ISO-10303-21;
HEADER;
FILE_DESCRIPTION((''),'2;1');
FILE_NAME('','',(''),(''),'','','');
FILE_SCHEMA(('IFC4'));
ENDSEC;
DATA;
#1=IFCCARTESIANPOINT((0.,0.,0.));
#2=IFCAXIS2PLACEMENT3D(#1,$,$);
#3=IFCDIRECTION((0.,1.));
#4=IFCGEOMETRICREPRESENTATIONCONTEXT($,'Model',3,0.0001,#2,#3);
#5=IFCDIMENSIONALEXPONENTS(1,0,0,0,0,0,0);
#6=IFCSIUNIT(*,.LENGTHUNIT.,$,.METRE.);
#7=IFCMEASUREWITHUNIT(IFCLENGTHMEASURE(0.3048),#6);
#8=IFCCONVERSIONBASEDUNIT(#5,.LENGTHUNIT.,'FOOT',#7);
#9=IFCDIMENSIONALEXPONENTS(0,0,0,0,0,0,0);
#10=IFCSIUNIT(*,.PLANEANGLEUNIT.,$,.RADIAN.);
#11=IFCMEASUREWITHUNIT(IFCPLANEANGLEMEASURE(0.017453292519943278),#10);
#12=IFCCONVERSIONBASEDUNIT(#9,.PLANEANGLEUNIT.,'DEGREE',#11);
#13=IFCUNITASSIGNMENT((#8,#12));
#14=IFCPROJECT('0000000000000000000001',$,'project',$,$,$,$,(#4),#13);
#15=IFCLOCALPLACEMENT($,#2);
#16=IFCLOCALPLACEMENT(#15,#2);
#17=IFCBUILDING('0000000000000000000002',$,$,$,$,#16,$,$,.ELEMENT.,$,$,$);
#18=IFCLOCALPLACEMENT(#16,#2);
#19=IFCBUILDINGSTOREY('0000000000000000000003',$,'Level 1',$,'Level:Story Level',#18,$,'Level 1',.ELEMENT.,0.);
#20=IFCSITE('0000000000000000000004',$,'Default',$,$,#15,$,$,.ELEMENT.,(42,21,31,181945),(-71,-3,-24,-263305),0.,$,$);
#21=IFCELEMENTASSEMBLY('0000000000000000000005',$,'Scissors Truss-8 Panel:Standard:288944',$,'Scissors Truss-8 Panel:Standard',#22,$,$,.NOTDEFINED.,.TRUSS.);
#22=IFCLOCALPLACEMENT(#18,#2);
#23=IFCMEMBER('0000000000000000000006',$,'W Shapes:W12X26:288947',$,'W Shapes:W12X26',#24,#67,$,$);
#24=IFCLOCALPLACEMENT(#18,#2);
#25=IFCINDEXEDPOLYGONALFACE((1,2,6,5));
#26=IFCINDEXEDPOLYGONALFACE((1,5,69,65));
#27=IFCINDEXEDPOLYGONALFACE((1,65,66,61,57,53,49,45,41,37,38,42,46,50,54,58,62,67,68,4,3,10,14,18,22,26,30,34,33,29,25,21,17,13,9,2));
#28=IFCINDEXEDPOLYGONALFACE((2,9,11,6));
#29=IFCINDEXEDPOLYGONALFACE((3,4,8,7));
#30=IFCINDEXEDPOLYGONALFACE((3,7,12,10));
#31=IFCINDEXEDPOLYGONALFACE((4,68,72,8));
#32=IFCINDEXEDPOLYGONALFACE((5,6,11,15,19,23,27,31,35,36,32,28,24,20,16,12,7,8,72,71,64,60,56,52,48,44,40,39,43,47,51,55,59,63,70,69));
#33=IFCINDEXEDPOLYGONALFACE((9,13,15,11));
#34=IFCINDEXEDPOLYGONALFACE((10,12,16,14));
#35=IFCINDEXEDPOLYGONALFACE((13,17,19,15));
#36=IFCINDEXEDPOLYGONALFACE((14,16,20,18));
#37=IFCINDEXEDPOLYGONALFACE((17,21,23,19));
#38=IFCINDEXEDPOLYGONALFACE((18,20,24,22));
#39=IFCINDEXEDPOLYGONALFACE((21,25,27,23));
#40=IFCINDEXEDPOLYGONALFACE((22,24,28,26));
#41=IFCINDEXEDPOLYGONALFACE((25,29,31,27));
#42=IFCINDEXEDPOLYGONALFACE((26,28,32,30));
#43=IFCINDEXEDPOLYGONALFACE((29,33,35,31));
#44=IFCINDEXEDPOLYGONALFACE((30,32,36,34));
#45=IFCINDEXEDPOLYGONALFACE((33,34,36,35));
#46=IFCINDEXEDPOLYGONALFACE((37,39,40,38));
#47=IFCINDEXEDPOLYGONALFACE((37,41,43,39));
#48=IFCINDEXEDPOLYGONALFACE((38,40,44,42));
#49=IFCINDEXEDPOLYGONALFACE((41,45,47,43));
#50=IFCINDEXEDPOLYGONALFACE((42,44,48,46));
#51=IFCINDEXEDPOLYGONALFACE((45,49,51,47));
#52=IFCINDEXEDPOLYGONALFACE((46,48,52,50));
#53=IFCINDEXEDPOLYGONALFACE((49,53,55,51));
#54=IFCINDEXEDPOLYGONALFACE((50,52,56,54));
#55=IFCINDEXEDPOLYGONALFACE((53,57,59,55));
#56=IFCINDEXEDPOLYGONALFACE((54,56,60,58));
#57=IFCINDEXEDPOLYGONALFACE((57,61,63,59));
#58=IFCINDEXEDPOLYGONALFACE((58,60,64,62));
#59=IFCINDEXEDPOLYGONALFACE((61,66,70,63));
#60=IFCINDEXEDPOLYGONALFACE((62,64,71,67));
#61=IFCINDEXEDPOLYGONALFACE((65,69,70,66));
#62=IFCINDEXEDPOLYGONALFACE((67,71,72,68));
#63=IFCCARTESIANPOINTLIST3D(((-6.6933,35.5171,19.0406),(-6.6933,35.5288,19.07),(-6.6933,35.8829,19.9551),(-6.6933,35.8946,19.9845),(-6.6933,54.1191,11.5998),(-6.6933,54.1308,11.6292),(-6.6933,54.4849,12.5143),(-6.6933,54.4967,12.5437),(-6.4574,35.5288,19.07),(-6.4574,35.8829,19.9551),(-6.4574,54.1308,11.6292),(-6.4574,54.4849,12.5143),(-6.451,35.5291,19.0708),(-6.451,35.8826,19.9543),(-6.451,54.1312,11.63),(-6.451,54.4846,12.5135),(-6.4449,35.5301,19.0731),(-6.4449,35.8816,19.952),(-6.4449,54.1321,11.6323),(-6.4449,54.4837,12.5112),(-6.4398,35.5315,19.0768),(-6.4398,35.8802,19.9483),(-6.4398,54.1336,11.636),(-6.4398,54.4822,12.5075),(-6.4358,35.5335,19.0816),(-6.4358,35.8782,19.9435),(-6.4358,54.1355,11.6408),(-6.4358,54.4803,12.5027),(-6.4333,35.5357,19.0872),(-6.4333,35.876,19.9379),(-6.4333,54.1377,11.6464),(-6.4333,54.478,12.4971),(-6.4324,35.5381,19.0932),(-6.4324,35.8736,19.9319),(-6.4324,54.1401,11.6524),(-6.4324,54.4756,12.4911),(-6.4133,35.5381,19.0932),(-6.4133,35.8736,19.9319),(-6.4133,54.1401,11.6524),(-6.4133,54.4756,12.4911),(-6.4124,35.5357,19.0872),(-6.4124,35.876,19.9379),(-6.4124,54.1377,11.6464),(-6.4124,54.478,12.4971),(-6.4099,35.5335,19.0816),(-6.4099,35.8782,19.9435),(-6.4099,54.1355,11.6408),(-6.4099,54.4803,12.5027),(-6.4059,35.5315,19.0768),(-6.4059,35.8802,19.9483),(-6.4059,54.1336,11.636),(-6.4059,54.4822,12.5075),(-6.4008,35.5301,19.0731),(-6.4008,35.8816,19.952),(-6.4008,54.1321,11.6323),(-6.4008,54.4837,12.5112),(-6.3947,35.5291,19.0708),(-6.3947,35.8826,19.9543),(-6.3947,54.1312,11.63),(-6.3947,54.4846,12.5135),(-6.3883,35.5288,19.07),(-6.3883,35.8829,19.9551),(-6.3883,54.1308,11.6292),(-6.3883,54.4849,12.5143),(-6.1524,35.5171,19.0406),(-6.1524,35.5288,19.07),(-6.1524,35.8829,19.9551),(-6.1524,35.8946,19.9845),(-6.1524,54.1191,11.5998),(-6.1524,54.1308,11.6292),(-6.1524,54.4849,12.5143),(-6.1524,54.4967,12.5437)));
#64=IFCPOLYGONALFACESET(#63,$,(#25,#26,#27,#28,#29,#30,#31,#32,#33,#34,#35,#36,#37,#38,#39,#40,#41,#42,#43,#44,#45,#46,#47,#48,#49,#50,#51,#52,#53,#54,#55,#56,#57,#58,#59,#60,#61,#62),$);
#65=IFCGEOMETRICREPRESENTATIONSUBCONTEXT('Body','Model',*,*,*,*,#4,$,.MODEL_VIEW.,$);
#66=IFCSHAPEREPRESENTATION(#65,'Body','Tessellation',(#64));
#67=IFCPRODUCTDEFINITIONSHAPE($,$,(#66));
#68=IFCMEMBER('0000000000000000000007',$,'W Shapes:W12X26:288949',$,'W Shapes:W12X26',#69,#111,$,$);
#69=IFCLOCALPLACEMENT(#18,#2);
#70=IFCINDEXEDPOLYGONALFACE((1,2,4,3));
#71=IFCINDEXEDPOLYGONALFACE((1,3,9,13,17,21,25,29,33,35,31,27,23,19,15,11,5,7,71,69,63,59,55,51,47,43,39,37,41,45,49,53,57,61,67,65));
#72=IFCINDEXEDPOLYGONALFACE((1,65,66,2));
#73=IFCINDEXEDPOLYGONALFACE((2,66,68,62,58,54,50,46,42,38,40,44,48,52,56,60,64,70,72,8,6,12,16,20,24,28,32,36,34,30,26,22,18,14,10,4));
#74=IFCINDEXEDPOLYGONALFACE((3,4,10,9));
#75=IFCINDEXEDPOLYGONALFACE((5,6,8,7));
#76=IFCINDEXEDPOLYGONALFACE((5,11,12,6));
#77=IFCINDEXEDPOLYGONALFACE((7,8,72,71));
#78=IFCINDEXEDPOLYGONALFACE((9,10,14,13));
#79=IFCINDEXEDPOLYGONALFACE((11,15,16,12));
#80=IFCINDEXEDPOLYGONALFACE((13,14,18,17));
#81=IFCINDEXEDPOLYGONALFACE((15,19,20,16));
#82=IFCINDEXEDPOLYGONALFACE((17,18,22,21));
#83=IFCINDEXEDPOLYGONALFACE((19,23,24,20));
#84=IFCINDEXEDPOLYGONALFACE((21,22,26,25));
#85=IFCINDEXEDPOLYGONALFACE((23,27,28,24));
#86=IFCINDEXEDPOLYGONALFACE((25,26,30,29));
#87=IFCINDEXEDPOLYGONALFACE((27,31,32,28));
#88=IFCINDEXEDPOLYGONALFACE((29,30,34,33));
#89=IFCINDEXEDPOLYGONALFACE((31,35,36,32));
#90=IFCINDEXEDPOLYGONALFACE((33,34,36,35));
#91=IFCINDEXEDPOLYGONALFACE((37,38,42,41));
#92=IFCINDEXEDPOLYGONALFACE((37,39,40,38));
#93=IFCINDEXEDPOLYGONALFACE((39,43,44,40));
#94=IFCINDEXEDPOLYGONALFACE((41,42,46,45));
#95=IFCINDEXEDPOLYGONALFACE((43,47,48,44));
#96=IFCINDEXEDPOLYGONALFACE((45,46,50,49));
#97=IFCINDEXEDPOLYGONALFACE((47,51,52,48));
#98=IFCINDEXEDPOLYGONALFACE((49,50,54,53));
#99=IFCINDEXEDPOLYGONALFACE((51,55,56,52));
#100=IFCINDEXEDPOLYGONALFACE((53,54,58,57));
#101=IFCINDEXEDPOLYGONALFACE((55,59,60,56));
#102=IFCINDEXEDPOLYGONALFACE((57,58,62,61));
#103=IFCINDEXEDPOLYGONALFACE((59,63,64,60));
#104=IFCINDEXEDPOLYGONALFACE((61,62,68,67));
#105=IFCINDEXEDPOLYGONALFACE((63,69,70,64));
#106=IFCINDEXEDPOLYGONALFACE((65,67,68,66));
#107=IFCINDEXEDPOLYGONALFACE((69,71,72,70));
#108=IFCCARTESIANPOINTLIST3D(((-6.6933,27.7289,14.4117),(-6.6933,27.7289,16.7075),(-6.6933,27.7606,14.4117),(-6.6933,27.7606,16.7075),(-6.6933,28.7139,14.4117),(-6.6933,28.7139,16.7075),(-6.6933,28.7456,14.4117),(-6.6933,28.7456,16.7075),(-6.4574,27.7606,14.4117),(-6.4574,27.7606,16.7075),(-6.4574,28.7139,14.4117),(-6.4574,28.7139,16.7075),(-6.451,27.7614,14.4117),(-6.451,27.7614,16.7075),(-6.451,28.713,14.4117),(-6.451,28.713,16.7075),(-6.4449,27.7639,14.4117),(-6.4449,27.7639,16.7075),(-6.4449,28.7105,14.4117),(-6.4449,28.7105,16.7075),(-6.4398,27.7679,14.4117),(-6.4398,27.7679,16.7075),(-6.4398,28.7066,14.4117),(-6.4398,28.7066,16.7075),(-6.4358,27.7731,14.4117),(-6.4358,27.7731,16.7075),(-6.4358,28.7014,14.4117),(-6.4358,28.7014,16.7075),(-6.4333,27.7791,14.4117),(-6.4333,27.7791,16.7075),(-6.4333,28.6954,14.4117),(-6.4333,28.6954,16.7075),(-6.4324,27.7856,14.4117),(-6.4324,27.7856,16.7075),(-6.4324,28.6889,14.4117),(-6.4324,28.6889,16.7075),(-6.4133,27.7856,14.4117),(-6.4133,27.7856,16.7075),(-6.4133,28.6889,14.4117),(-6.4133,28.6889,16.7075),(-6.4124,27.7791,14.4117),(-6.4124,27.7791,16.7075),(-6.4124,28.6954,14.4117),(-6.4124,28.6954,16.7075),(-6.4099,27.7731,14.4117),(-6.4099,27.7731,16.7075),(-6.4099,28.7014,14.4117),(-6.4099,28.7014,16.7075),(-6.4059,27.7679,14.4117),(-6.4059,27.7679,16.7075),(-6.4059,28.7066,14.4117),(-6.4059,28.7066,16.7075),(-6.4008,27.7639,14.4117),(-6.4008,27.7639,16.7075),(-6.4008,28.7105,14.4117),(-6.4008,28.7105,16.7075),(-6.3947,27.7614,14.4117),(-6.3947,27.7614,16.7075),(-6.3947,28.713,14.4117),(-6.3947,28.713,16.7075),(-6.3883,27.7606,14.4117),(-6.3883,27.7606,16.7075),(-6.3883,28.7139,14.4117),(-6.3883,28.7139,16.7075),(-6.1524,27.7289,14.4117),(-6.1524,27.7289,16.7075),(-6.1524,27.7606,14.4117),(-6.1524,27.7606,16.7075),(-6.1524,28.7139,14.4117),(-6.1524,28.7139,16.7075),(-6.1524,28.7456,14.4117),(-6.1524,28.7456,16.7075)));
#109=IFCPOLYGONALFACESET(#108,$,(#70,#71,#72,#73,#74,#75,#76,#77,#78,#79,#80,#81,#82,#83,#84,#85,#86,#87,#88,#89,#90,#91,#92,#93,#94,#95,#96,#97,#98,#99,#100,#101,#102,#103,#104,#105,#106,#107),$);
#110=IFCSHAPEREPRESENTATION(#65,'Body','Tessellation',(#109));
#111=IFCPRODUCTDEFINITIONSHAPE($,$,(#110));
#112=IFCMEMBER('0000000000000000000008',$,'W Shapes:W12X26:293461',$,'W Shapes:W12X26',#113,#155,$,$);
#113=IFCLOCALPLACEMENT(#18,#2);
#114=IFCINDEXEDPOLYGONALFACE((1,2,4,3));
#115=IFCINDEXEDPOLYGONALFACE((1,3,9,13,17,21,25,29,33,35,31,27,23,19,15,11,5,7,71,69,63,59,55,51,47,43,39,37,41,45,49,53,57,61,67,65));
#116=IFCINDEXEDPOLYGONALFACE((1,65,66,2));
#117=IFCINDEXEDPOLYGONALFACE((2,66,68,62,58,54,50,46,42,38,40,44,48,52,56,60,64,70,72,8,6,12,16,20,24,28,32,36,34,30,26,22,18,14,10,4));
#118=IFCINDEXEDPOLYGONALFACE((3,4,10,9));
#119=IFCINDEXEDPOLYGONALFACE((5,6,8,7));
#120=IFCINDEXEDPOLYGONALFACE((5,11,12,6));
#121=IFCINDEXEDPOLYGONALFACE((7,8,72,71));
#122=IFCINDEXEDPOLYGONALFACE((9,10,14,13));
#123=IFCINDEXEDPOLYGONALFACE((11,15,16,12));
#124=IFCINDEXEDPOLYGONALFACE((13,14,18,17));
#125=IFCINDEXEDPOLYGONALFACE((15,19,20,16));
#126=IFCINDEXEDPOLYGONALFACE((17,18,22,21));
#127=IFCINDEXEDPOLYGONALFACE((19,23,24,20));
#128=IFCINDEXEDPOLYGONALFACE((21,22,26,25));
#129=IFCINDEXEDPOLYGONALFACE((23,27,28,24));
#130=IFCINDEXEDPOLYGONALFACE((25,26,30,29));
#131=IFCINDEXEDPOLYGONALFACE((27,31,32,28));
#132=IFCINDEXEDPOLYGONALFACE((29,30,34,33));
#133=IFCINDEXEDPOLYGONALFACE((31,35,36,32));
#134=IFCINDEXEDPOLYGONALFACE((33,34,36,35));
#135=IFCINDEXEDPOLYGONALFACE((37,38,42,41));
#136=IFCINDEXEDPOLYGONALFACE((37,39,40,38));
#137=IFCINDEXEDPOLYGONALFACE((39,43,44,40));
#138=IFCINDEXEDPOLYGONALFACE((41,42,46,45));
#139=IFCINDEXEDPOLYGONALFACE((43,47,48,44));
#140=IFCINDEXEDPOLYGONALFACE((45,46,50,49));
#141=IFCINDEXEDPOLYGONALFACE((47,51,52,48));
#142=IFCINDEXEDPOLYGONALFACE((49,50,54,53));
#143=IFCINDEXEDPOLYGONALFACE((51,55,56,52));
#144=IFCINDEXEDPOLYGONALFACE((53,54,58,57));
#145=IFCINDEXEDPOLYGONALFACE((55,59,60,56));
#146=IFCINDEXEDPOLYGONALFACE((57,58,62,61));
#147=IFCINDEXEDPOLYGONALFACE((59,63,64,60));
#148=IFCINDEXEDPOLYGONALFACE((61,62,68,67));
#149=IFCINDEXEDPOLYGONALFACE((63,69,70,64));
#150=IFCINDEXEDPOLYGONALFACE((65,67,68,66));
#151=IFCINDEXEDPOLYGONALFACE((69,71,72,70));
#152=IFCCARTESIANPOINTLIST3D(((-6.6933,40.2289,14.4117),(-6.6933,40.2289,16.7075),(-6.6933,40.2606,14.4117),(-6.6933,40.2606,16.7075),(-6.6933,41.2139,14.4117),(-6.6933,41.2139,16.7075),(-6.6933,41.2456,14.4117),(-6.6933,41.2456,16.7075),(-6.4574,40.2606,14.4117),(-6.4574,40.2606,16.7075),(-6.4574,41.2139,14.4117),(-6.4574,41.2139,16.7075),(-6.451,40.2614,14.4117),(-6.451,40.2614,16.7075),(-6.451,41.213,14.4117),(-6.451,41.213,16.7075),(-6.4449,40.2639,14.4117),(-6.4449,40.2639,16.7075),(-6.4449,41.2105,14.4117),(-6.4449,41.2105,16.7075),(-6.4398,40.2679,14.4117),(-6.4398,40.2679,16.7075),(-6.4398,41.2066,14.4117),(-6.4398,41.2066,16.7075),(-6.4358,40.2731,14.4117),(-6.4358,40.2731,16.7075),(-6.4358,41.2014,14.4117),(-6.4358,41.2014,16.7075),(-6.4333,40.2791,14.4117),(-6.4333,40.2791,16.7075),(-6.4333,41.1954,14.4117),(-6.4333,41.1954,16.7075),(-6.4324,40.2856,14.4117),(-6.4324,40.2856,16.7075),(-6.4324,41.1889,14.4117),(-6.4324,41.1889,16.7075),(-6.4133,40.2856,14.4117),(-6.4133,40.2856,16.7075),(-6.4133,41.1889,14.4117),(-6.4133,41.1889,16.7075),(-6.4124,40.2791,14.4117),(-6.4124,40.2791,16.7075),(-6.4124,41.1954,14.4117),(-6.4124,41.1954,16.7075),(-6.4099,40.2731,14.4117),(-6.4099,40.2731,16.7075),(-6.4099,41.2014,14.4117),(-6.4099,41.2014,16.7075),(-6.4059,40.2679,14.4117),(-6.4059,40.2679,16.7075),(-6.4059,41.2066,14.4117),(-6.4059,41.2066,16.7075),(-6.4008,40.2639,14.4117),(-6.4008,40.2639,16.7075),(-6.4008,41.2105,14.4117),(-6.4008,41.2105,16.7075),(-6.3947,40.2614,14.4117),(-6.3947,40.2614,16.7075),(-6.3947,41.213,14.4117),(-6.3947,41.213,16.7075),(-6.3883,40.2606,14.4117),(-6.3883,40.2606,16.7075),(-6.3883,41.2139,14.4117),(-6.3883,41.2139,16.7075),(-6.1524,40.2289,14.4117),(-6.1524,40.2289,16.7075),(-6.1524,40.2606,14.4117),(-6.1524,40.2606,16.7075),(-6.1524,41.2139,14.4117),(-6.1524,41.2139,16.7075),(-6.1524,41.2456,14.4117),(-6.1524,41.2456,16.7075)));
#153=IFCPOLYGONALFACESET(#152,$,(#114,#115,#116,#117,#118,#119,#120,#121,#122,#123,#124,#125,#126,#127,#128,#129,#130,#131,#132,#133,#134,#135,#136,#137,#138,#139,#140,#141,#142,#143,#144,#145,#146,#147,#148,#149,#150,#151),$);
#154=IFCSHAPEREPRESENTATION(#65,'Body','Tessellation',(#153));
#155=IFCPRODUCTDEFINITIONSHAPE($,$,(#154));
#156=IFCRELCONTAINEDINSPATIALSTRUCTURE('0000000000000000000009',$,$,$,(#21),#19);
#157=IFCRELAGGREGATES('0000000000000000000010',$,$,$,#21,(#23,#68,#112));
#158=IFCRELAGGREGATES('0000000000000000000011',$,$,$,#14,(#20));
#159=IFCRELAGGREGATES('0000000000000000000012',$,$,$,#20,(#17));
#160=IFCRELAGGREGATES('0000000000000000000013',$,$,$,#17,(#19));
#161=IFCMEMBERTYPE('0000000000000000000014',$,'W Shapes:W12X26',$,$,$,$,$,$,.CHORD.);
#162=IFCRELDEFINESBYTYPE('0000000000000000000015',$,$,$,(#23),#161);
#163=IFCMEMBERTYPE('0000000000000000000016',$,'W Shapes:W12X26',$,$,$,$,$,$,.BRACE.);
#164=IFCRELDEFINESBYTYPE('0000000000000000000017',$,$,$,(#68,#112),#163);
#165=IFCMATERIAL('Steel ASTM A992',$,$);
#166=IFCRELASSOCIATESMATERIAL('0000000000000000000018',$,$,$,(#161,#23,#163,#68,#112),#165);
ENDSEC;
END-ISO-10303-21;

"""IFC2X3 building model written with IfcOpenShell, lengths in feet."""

from ifc_helpers import new_model, entity, si_unit, converted_unit, direction, frame, frame_2d, origin, place, context, subcontext, project, spatial, polyline, circle_curve, parameter, trimmed, segment, composite_curve, outline, extrude, source, transform, mapped, material, type_object, type_shapes, element, aggregate, save


model = new_model("IFC2X3")

# Units and contexts
model_context = context("Model", 3, precision=0.0001, world=origin(), true_north=direction((0.0, 1.0)))
body_context = subcontext(model_context, "Body", "Model", "MODEL_VIEW")
ifc_project = project(units=[converted_unit("LENGTHUNIT", "FOOT", entity("IfcLengthMeasure", 0.3048), si_unit("LENGTHUNIT", "METRE"), dimensions=[1, 0, 0, 0, 0, 0, 0]), converted_unit("PLANEANGLEUNIT", "DEGREE", entity("IfcPlaneAngleMeasure", 0.017453292519943278), si_unit("PLANEANGLEUNIT", "RADIAN"), dimensions=[0, 0, 0, 0, 0, 0, 0])], contexts=[model_context])

# Site, building, storey
site_placement = place(None, origin())
site = spatial("IfcSite", under=ifc_project, at=site_placement, Name="Default", CompositionType="ELEMENT", RefLatitude=(42, 21, 31, 181945), RefLongitude=(-71, -3, -24, -263305), RefElevation=0.0)
building_placement = place(site_placement, origin())
building = spatial("IfcBuilding", under=site, at=building_placement, CompositionType="ELEMENT")
storey_placement = place(building_placement, origin())
storey = spatial("IfcBuildingStorey", under=building, at=storey_placement, Name="Level 1", ObjectType="Level:Story Level", LongName="Level 1", CompositionType="ELEMENT", Elevation=0.0)

# Element assembly, members
assembly_placement = place(storey_placement, origin())
assembly = element("IfcElementAssembly", 1, at=assembly_placement, inside=storey, Name="Scissors Truss-8 Panel:Standard:288944", ObjectType="Scissors Truss-8 Panel:Standard", AssemblyPlace="NOTDEFINED", PredefinedType="TRUSS")
ifc_material = material(Name="Steel ASTM A992")
member_type_1 = type_object("IfcMemberType", Name="W Shapes:W12X26", PredefinedType="CHORD", material=ifc_material)
shared_shape_1 = source(origin(), body_context, "Body", "SweptSolid", [
    extrude(outline(composite_curve([segment(polyline([(0.4767, -0.2704), (0.5083, -0.2704)]), True, "CONTINUOUS"), segment(polyline([(0.5083, -0.2704), (0.5083, 0.2704)]), True, "CONTINUOUS"), segment(polyline([(0.5083, 0.2704), (0.4767, 0.2704)]), True, "CONTINUOUS"), segment(polyline([(0.4767, 0.2704), (0.4767, 0.0346)]), True, "CONTINUOUS"), segment(trimmed(circle_curve(frame_2d((0.4517, 0.0346), x_axis=(1.0, 0.0)), 0.025), [parameter(270.0)], [parameter(0.0)], True, "PARAMETER"), False, "CONTINUOUS"), segment(polyline([(0.4517, 0.0096), (-0.4517, 0.0096)]), True, "CONTINUOUS"), segment(trimmed(circle_curve(frame_2d((-0.4517, 0.0346), x_axis=(0.0, -1.0)), 0.025), [parameter(270.0)], [parameter(0.0)], True, "PARAMETER"), False, "CONTINUOUS"), segment(polyline([(-0.4767, 0.0346), (-0.4767, 0.2704)]), True, "CONTINUOUS"), segment(polyline([(-0.4767, 0.2704), (-0.5083, 0.2704)]), True, "CONTINUOUS"), segment(polyline([(-0.5083, 0.2704), (-0.5083, -0.2704)]), True, "CONTINUOUS"), segment(polyline([(-0.5083, -0.2704), (-0.4767, -0.2704)]), True, "CONTINUOUS"), segment(polyline([(-0.4767, -0.2704), (-0.4767, -0.0346)]), True, "CONTINUOUS"), segment(trimmed(circle_curve(frame_2d((-0.4517, -0.0346), x_axis=(-1.0, 0.0)), 0.025), [parameter(270.0)], [parameter(0.0)], True, "PARAMETER"), False, "CONTINUOUS"), segment(polyline([(-0.4517, -0.0096), (0.4517, -0.0096)]), True, "CONTINUOUS"), segment(trimmed(circle_curve(frame_2d((0.4517, -0.0346), x_axis=(0.0, 1.0)), 0.025), [parameter(270.0)], [parameter(0.0)], True, "PARAMETER"), False, "CONTINUOUS"), segment(polyline([(0.4767, -0.0346), (0.4767, -0.2704)]), True, "CONTINUOUS")], self_intersect=False)), frame((-6.4228, 35.7059, 19.5125), z_axis=(0.0, 0.928477, -0.371391), x_axis=(0.0, 0.371391, 0.928477)), (0.0, 0.0, 1.0), 20.035),
])
type_shapes(member_type_1, [shared_shape_1])
member_1_placement = place(assembly_placement, origin())
member_1 = element("IfcMember", 2, at=member_1_placement, type_object=member_type_1, material=ifc_material, Name="W Shapes:W12X26:288947", ObjectType="W Shapes:W12X26", context=body_context, shape_type="MappedRepresentation", body=[
    mapped(shared_shape_1, transform((0.0, 0.0, 0.0), scale=1.0)),
])
member_type_2 = type_object("IfcMemberType", Name="W Shapes:W12X26", PredefinedType="BRACE", material=ifc_material)
shared_shape_2 = source(origin(), body_context, "Body", "SweptSolid", [
    extrude(outline(composite_curve([segment(polyline([(-0.2704, -0.4767), (-0.2704, -0.5083)]), True, "CONTINUOUS"), segment(polyline([(-0.2704, -0.5083), (0.2704, -0.5083)]), True, "CONTINUOUS"), segment(polyline([(0.2704, -0.5083), (0.2704, -0.4767)]), True, "CONTINUOUS"), segment(polyline([(0.2704, -0.4767), (0.0346, -0.4767)]), True, "CONTINUOUS"), segment(trimmed(circle_curve(frame_2d((0.0346, -0.4517), x_axis=(1.0, 0.0)), 0.025), [parameter(180.0)], [parameter(270.0)], True, "PARAMETER"), False, "CONTINUOUS"), segment(polyline([(0.0096, -0.4517), (0.0096, 0.4517)]), True, "CONTINUOUS"), segment(trimmed(circle_curve(frame_2d((0.0346, 0.4517), x_axis=(1.0, 0.0)), 0.025), [parameter(90.0)], [parameter(180.0)], True, "PARAMETER"), False, "CONTINUOUS"), segment(polyline([(0.0346, 0.4767), (0.2704, 0.4767)]), True, "CONTINUOUS"), segment(polyline([(0.2704, 0.4767), (0.2704, 0.5083)]), True, "CONTINUOUS"), segment(polyline([(0.2704, 0.5083), (-0.2704, 0.5083)]), True, "CONTINUOUS"), segment(polyline([(-0.2704, 0.5083), (-0.2704, 0.4767)]), True, "CONTINUOUS"), segment(polyline([(-0.2704, 0.4767), (-0.0346, 0.4767)]), True, "CONTINUOUS"), segment(trimmed(circle_curve(frame_2d((-0.0346, 0.4517), x_axis=(1.0, 0.0)), 0.025), [parameter(360.0)], [parameter(90.0)], True, "PARAMETER"), False, "CONTINUOUS"), segment(polyline([(-0.0096, 0.4517), (-0.0096, -0.4517)]), True, "CONTINUOUS"), segment(trimmed(circle_curve(frame_2d((-0.0346, -0.4517), x_axis=(1.0, 0.0)), 0.025), [parameter(270.0)], [parameter(360.0)], True, "PARAMETER"), False, "CONTINUOUS"), segment(polyline([(-0.0346, -0.4767), (-0.2704, -0.4767)]), True, "CONTINUOUS")], self_intersect=False)), frame((-1.2133, 0.0, 0.0), z_axis=(-1.0, 0.0, 0.0), x_axis=(0.0, -1.0, 0.0)), (0.0, 0.0, -1.0), 2.2958),
])
type_shapes(member_type_2, [shared_shape_2])
member_2_placement = place(assembly_placement, frame((-6.4228, 28.2372, 15.625), z_axis=(0.0, 1.0, 0.0), x_axis=(0.0, 0.0, 1.0)))
member_2 = element("IfcMember", 3, at=member_2_placement, type_object=member_type_2, material=ifc_material, Name="W Shapes:W12X26:288949", ObjectType="W Shapes:W12X26", context=body_context, shape_type="MappedRepresentation", body=[
    mapped(shared_shape_2, transform((0.0, 0.0, 0.0), scale=1.0)),
])
member_3_placement = place(assembly_placement, frame((-6.4228, 40.7372, 15.625), z_axis=(0.0, 1.0, 0.0), x_axis=(0.0, 0.0, 1.0)))
member_3 = element("IfcMember", 4, at=member_3_placement, type_object=member_type_2, material=ifc_material, Name="W Shapes:W12X26:293461", ObjectType="W Shapes:W12X26", context=body_context, shape_type="MappedRepresentation", body=[
    mapped(shared_shape_2, transform((0.0, 0.0, 0.0), scale=1.0)),
])
aggregate(assembly, [member_1, member_2, member_3])

save(model, "model.ifc")
